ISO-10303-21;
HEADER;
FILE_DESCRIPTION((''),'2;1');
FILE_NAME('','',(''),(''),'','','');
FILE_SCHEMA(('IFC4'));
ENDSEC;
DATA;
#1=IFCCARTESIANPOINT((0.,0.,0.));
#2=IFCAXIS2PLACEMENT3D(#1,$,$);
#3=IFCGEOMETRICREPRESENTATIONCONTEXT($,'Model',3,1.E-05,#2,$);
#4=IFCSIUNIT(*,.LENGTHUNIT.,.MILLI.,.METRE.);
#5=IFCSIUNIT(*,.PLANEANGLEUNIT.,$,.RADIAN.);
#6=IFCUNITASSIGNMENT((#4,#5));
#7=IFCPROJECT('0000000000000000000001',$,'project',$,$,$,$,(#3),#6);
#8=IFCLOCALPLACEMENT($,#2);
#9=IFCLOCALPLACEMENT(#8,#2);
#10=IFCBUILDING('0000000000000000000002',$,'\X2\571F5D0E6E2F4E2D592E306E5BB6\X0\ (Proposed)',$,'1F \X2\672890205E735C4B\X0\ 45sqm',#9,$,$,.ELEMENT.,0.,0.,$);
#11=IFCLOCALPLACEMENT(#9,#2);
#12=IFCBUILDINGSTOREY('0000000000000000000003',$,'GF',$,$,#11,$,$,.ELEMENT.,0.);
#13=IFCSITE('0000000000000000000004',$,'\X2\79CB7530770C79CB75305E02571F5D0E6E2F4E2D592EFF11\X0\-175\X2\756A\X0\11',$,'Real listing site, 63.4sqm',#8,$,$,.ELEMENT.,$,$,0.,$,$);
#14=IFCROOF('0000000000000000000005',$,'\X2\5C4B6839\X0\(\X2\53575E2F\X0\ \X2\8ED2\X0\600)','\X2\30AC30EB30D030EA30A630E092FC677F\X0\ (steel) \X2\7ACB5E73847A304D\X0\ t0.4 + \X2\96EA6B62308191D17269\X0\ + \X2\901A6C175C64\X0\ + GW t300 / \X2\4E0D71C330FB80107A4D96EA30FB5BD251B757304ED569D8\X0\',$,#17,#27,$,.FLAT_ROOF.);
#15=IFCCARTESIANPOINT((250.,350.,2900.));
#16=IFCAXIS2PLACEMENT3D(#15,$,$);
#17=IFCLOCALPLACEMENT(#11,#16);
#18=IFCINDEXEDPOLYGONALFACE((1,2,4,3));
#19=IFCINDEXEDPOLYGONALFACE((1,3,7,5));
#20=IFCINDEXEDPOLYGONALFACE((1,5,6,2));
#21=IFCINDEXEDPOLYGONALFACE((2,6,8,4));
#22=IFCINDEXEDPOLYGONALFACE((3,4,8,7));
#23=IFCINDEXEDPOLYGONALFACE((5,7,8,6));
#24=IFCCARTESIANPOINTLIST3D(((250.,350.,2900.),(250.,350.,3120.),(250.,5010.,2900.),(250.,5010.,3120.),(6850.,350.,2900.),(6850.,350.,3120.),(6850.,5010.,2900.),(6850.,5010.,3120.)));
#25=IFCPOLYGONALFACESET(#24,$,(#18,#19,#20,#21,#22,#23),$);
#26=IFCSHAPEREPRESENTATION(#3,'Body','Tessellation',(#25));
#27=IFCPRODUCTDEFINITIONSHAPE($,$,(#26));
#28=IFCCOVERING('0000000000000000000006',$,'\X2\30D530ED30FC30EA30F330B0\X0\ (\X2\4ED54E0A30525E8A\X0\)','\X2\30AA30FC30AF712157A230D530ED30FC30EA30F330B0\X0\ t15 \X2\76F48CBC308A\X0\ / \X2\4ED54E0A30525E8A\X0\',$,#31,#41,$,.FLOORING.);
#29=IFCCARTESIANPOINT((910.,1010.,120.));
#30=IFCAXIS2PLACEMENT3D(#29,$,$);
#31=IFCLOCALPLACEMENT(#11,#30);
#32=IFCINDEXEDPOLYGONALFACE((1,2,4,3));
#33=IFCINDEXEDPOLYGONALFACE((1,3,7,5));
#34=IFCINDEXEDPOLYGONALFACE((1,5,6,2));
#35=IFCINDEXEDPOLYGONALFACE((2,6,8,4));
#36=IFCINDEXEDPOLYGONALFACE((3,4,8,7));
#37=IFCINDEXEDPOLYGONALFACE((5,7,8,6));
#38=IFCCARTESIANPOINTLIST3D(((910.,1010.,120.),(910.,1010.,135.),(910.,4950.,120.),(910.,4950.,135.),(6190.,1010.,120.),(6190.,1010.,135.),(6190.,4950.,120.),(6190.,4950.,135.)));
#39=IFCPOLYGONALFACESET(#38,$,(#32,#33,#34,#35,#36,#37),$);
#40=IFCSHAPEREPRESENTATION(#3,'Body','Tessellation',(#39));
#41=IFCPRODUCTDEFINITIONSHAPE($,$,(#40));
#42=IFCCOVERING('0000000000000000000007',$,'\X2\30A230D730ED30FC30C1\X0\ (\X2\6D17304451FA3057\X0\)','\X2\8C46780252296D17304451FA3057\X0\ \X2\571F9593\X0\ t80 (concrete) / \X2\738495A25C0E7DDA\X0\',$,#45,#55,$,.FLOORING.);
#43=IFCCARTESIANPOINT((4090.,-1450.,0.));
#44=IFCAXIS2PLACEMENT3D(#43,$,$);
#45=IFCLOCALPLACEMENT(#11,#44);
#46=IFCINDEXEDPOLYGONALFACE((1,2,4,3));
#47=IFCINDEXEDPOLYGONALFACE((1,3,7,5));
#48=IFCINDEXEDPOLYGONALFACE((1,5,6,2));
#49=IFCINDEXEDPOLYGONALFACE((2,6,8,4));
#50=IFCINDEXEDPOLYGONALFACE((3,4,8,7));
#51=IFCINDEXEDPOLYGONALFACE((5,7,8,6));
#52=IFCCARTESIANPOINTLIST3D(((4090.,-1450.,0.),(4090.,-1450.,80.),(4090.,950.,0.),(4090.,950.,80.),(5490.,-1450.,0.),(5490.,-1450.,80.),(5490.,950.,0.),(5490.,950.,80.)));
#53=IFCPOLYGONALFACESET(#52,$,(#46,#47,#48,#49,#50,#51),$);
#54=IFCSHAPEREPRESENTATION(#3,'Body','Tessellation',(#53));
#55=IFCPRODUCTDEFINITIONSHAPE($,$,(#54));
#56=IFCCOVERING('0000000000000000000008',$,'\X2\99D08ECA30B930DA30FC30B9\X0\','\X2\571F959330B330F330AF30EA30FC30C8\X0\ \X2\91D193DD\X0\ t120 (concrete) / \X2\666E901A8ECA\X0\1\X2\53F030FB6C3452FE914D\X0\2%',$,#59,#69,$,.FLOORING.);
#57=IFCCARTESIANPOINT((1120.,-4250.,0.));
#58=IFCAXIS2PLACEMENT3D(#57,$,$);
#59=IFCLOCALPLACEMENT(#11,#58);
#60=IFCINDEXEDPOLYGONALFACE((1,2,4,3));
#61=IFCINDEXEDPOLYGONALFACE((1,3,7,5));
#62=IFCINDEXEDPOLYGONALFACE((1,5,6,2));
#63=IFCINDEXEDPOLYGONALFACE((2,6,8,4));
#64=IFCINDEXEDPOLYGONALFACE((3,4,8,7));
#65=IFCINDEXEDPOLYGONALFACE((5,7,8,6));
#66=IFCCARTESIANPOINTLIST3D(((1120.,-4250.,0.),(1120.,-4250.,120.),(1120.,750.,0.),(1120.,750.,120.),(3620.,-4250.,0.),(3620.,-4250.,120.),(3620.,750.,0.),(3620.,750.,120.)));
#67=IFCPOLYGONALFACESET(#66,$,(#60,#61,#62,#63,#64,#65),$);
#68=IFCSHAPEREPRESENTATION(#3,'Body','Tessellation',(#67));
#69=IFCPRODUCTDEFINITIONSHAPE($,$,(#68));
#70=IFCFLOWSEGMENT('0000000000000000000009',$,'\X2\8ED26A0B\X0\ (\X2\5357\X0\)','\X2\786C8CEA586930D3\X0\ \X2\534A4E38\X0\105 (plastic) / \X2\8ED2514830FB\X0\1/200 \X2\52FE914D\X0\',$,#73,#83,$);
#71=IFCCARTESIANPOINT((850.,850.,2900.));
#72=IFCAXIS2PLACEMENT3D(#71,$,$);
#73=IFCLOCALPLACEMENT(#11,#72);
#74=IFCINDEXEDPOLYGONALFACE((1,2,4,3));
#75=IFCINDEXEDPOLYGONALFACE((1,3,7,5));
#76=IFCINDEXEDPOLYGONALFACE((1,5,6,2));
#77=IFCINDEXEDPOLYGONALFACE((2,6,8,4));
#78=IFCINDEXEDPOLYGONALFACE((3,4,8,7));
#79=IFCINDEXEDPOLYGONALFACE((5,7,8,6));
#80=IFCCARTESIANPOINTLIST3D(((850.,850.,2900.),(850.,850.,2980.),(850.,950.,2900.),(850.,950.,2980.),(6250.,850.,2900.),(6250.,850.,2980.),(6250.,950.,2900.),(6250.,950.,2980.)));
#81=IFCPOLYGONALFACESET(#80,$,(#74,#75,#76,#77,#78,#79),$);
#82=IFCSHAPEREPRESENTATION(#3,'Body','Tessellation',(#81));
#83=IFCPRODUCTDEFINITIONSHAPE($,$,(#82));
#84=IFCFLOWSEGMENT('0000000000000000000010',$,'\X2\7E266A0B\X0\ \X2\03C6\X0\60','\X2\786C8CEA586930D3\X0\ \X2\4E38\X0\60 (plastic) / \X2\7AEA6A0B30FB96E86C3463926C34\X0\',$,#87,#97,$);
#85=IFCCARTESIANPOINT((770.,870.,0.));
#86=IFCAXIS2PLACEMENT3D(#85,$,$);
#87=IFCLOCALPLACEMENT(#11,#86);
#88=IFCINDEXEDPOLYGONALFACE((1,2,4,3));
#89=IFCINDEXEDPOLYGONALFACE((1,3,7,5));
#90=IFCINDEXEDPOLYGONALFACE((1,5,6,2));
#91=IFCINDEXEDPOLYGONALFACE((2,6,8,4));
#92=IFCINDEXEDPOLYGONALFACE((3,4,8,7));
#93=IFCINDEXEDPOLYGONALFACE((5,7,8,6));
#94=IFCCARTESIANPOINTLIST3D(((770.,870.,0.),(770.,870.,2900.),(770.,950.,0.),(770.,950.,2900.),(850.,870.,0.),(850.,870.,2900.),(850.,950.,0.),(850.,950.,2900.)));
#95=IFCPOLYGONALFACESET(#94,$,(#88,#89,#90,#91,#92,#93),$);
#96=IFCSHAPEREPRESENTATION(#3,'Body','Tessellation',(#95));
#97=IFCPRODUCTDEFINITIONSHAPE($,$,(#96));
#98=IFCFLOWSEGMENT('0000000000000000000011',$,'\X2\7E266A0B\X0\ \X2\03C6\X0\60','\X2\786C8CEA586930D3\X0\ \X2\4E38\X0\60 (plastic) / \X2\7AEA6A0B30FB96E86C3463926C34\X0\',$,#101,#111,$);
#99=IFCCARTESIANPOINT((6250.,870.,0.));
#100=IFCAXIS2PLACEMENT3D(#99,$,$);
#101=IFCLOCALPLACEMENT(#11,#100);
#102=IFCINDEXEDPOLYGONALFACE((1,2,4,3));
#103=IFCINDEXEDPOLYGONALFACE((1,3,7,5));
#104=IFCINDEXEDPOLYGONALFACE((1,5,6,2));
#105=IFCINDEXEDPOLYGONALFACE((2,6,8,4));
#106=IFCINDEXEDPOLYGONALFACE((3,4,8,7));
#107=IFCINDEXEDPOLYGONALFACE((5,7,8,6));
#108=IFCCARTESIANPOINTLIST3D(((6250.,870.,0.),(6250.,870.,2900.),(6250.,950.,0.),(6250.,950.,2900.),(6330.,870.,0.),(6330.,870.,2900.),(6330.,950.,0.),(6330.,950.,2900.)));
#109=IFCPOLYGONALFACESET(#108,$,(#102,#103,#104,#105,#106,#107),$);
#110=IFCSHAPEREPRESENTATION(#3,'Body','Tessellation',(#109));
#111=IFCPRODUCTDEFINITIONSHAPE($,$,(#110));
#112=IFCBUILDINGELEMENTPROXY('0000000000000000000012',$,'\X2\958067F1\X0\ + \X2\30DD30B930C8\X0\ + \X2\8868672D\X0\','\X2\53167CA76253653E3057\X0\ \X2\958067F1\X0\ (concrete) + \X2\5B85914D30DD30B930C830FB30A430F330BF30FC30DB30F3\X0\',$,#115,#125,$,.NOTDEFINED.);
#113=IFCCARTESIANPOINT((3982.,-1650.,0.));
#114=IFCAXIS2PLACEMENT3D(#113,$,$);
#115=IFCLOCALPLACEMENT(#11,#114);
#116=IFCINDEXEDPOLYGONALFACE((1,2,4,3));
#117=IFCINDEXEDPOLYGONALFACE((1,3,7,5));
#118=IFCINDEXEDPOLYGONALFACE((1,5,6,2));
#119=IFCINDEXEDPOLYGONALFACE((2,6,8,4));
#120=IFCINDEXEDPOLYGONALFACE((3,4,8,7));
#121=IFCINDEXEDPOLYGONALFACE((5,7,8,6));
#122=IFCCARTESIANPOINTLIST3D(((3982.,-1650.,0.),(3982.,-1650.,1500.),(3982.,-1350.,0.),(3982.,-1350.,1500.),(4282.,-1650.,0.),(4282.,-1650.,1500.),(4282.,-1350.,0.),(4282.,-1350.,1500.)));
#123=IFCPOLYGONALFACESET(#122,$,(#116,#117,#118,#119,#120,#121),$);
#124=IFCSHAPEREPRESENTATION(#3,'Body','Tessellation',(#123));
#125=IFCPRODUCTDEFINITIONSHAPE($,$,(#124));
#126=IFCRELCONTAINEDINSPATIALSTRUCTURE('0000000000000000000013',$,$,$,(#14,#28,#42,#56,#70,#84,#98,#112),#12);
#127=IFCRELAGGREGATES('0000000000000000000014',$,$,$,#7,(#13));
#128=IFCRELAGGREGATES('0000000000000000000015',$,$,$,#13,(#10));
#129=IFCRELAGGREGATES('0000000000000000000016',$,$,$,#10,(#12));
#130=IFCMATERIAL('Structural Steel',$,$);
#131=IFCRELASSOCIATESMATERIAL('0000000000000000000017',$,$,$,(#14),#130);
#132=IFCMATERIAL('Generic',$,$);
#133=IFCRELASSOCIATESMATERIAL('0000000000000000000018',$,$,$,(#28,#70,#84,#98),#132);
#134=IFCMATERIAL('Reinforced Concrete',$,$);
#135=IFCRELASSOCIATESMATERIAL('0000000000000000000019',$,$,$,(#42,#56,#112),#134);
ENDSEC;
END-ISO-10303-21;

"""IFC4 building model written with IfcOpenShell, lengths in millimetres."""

from ifc_helpers import new_model, si_unit, frame, frame_2d, origin, place, context, project, spatial, rectangle, extrude, material, element, save


model = new_model("IFC4")

# Units and contexts
model_context = context("Model", 3, precision=1e-05, world=origin())
ifc_project = project(units=[si_unit("LENGTHUNIT", "METRE", prefix="MILLI"), si_unit("PLANEANGLEUNIT", "RADIAN")], contexts=[model_context])

# Site, building, storey
site_placement = place(None, origin())
site = spatial("IfcSite", under=ifc_project, at=site_placement, Name="秋田県秋田市土崎港中央１-175番11", ObjectType="Real listing site, 63.4sqm", CompositionType="ELEMENT", RefElevation=0.0)
building_placement = place(site_placement, origin())
building = spatial("IfcBuilding", under=site, at=building_placement, Name="土崎港中央の家 (Proposed)", ObjectType="1F 木造平屋 45sqm", CompositionType="ELEMENT", ElevationOfRefHeight=0.0, ElevationOfTerrain=0.0)
storey_placement = place(building_placement, origin())
storey = spatial("IfcBuildingStorey", under=building, at=storey_placement, Name="GF", CompositionType="ELEMENT", Elevation=0.0)

# Shared definitions
ifc_material_1 = material(Name="Reinforced Concrete")

# Roof
ifc_material_2 = material(Name="Structural Steel")
roof_placement = place(storey_placement, frame((250.0, 350.0, 2900.0)))
element("IfcRoof", 1, at=roof_placement, inside=storey, material=ifc_material_2, Name="屋根(南帯 軒600)", Description="ガルバリウム鋼板 (steel) 立平葺き t0.4 + 雪止め金物 + 通気層 + GW t300 / 不燃・耐積雪・寒冷地仕様", PredefinedType="FLAT_ROOF", context=model_context, shape_type="SweptSolid", body=[
    extrude(rectangle(XDim=6600.0, YDim=4660.0, at=frame_2d((3300.0, 2330.0))), frame((250.0, 350.0, 2900.0)), (0.0, 0.0, 1.0), 220.0),
])

# Coverings
ifc_material_3 = material(Name="Generic")
covering_1_placement = place(storey_placement, frame((910.0, 1010.0, 120.0)))
element("IfcCovering", 2, at=covering_1_placement, inside=storey, material=ifc_material_3, Name="フローリング (仕上げ床)", Description="オーク無垢フローリング t15 直貼り / 仕上げ床", PredefinedType="FLOORING", context=model_context, shape_type="SweptSolid", body=[
    extrude(rectangle(XDim=5280.0, YDim=3940.0, at=frame_2d((2640.0, 1970.0))), frame((910.0, 1010.0, 120.0)), (0.0, 0.0, 1.0), 15.0),
])
covering_2_placement = place(storey_placement, frame((4090.0, -1450.0, 0.0)))
element("IfcCovering", 3, at=covering_2_placement, inside=storey, material=ifc_material_1, Name="アプローチ (洗い出し)", Description="豆砂利洗い出し 土間 t80 (concrete) / 玄関導線", PredefinedType="FLOORING", context=model_context, shape_type="SweptSolid", body=[
    extrude(rectangle(XDim=1400.0, YDim=2400.0, at=frame_2d((700.0, 1200.0))), frame((4090.0, -1450.0, 0.0)), (0.0, 0.0, 1.0), 80.0),
])
covering_3_placement = place(storey_placement, frame((1120.0, -4250.0, 0.0)))
element("IfcCovering", 4, at=covering_3_placement, inside=storey, material=ifc_material_1, Name="駐車スペース", Description="土間コンクリート 金鏝 t120 (concrete) / 普通車1台・水勾配2%", PredefinedType="FLOORING", context=model_context, shape_type="SweptSolid", body=[
    extrude(rectangle(XDim=2500.0, YDim=5000.0, at=frame_2d((1250.0, 2500.0))), frame((1120.0, -4250.0, 0.0)), (0.0, 0.0, 1.0), 120.0),
])

# Flow segments
flow_segment_1_placement = place(storey_placement, frame((850.0, 850.0, 2900.0)))
element("IfcFlowSegment", 5, at=flow_segment_1_placement, inside=storey, material=ifc_material_3, Name="軒樋 (南)", Description="硬質塩ビ 半丸105 (plastic) / 軒先・1/200 勾配", context=model_context, shape_type="SweptSolid", body=[
    extrude(rectangle(XDim=5400.0, YDim=100.0, at=frame_2d((2700.0, 50.0))), frame((850.0, 850.0, 2900.0)), (0.0, 0.0, 1.0), 80.0),
])
flow_segment_2_placement = place(storey_placement, frame((770.0, 870.0, 0.0)))
element("IfcFlowSegment", 6, at=flow_segment_2_placement, inside=storey, material=ifc_material_3, Name="縦樋 φ60", Description="硬質塩ビ 丸60 (plastic) / 竪樋・雨水排水", context=model_context, shape_type="SweptSolid", body=[
    extrude(rectangle(XDim=80.0, YDim=80.0, at=frame_2d((40.0, 40.0))), frame((770.0, 870.0, 0.0)), (0.0, 0.0, 1.0), 2900.0),
])
flow_segment_3_placement = place(storey_placement, frame((6250.0, 870.0, 0.0)))
element("IfcFlowSegment", 7, at=flow_segment_3_placement, inside=storey, material=ifc_material_3, Name="縦樋 φ60", Description="硬質塩ビ 丸60 (plastic) / 竪樋・雨水排水", context=model_context, shape_type="SweptSolid", body=[
    extrude(rectangle(XDim=80.0, YDim=80.0, at=frame_2d((40.0, 40.0))), frame((6250.0, 870.0, 0.0)), (0.0, 0.0, 1.0), 2900.0),
])

# Building element proxy
proxy_placement = place(storey_placement, frame((3982.0, -1650.0, 0.0)))
element("IfcBuildingElementProxy", 8, at=proxy_placement, inside=storey, material=ifc_material_1, Name="門柱 + ポスト + 表札", Description="化粧打放し 門柱 (concrete) + 宅配ポスト・インターホン", PredefinedType="NOTDEFINED", context=model_context, shape_type="SweptSolid", body=[
    extrude(rectangle(XDim=300.0, YDim=300.0, at=frame_2d((150.0, 150.0))), frame((3982.0, -1650.0, 0.0)), (0.0, 0.0, 1.0), 1500.0),
])

save(model, "model.ifc")
